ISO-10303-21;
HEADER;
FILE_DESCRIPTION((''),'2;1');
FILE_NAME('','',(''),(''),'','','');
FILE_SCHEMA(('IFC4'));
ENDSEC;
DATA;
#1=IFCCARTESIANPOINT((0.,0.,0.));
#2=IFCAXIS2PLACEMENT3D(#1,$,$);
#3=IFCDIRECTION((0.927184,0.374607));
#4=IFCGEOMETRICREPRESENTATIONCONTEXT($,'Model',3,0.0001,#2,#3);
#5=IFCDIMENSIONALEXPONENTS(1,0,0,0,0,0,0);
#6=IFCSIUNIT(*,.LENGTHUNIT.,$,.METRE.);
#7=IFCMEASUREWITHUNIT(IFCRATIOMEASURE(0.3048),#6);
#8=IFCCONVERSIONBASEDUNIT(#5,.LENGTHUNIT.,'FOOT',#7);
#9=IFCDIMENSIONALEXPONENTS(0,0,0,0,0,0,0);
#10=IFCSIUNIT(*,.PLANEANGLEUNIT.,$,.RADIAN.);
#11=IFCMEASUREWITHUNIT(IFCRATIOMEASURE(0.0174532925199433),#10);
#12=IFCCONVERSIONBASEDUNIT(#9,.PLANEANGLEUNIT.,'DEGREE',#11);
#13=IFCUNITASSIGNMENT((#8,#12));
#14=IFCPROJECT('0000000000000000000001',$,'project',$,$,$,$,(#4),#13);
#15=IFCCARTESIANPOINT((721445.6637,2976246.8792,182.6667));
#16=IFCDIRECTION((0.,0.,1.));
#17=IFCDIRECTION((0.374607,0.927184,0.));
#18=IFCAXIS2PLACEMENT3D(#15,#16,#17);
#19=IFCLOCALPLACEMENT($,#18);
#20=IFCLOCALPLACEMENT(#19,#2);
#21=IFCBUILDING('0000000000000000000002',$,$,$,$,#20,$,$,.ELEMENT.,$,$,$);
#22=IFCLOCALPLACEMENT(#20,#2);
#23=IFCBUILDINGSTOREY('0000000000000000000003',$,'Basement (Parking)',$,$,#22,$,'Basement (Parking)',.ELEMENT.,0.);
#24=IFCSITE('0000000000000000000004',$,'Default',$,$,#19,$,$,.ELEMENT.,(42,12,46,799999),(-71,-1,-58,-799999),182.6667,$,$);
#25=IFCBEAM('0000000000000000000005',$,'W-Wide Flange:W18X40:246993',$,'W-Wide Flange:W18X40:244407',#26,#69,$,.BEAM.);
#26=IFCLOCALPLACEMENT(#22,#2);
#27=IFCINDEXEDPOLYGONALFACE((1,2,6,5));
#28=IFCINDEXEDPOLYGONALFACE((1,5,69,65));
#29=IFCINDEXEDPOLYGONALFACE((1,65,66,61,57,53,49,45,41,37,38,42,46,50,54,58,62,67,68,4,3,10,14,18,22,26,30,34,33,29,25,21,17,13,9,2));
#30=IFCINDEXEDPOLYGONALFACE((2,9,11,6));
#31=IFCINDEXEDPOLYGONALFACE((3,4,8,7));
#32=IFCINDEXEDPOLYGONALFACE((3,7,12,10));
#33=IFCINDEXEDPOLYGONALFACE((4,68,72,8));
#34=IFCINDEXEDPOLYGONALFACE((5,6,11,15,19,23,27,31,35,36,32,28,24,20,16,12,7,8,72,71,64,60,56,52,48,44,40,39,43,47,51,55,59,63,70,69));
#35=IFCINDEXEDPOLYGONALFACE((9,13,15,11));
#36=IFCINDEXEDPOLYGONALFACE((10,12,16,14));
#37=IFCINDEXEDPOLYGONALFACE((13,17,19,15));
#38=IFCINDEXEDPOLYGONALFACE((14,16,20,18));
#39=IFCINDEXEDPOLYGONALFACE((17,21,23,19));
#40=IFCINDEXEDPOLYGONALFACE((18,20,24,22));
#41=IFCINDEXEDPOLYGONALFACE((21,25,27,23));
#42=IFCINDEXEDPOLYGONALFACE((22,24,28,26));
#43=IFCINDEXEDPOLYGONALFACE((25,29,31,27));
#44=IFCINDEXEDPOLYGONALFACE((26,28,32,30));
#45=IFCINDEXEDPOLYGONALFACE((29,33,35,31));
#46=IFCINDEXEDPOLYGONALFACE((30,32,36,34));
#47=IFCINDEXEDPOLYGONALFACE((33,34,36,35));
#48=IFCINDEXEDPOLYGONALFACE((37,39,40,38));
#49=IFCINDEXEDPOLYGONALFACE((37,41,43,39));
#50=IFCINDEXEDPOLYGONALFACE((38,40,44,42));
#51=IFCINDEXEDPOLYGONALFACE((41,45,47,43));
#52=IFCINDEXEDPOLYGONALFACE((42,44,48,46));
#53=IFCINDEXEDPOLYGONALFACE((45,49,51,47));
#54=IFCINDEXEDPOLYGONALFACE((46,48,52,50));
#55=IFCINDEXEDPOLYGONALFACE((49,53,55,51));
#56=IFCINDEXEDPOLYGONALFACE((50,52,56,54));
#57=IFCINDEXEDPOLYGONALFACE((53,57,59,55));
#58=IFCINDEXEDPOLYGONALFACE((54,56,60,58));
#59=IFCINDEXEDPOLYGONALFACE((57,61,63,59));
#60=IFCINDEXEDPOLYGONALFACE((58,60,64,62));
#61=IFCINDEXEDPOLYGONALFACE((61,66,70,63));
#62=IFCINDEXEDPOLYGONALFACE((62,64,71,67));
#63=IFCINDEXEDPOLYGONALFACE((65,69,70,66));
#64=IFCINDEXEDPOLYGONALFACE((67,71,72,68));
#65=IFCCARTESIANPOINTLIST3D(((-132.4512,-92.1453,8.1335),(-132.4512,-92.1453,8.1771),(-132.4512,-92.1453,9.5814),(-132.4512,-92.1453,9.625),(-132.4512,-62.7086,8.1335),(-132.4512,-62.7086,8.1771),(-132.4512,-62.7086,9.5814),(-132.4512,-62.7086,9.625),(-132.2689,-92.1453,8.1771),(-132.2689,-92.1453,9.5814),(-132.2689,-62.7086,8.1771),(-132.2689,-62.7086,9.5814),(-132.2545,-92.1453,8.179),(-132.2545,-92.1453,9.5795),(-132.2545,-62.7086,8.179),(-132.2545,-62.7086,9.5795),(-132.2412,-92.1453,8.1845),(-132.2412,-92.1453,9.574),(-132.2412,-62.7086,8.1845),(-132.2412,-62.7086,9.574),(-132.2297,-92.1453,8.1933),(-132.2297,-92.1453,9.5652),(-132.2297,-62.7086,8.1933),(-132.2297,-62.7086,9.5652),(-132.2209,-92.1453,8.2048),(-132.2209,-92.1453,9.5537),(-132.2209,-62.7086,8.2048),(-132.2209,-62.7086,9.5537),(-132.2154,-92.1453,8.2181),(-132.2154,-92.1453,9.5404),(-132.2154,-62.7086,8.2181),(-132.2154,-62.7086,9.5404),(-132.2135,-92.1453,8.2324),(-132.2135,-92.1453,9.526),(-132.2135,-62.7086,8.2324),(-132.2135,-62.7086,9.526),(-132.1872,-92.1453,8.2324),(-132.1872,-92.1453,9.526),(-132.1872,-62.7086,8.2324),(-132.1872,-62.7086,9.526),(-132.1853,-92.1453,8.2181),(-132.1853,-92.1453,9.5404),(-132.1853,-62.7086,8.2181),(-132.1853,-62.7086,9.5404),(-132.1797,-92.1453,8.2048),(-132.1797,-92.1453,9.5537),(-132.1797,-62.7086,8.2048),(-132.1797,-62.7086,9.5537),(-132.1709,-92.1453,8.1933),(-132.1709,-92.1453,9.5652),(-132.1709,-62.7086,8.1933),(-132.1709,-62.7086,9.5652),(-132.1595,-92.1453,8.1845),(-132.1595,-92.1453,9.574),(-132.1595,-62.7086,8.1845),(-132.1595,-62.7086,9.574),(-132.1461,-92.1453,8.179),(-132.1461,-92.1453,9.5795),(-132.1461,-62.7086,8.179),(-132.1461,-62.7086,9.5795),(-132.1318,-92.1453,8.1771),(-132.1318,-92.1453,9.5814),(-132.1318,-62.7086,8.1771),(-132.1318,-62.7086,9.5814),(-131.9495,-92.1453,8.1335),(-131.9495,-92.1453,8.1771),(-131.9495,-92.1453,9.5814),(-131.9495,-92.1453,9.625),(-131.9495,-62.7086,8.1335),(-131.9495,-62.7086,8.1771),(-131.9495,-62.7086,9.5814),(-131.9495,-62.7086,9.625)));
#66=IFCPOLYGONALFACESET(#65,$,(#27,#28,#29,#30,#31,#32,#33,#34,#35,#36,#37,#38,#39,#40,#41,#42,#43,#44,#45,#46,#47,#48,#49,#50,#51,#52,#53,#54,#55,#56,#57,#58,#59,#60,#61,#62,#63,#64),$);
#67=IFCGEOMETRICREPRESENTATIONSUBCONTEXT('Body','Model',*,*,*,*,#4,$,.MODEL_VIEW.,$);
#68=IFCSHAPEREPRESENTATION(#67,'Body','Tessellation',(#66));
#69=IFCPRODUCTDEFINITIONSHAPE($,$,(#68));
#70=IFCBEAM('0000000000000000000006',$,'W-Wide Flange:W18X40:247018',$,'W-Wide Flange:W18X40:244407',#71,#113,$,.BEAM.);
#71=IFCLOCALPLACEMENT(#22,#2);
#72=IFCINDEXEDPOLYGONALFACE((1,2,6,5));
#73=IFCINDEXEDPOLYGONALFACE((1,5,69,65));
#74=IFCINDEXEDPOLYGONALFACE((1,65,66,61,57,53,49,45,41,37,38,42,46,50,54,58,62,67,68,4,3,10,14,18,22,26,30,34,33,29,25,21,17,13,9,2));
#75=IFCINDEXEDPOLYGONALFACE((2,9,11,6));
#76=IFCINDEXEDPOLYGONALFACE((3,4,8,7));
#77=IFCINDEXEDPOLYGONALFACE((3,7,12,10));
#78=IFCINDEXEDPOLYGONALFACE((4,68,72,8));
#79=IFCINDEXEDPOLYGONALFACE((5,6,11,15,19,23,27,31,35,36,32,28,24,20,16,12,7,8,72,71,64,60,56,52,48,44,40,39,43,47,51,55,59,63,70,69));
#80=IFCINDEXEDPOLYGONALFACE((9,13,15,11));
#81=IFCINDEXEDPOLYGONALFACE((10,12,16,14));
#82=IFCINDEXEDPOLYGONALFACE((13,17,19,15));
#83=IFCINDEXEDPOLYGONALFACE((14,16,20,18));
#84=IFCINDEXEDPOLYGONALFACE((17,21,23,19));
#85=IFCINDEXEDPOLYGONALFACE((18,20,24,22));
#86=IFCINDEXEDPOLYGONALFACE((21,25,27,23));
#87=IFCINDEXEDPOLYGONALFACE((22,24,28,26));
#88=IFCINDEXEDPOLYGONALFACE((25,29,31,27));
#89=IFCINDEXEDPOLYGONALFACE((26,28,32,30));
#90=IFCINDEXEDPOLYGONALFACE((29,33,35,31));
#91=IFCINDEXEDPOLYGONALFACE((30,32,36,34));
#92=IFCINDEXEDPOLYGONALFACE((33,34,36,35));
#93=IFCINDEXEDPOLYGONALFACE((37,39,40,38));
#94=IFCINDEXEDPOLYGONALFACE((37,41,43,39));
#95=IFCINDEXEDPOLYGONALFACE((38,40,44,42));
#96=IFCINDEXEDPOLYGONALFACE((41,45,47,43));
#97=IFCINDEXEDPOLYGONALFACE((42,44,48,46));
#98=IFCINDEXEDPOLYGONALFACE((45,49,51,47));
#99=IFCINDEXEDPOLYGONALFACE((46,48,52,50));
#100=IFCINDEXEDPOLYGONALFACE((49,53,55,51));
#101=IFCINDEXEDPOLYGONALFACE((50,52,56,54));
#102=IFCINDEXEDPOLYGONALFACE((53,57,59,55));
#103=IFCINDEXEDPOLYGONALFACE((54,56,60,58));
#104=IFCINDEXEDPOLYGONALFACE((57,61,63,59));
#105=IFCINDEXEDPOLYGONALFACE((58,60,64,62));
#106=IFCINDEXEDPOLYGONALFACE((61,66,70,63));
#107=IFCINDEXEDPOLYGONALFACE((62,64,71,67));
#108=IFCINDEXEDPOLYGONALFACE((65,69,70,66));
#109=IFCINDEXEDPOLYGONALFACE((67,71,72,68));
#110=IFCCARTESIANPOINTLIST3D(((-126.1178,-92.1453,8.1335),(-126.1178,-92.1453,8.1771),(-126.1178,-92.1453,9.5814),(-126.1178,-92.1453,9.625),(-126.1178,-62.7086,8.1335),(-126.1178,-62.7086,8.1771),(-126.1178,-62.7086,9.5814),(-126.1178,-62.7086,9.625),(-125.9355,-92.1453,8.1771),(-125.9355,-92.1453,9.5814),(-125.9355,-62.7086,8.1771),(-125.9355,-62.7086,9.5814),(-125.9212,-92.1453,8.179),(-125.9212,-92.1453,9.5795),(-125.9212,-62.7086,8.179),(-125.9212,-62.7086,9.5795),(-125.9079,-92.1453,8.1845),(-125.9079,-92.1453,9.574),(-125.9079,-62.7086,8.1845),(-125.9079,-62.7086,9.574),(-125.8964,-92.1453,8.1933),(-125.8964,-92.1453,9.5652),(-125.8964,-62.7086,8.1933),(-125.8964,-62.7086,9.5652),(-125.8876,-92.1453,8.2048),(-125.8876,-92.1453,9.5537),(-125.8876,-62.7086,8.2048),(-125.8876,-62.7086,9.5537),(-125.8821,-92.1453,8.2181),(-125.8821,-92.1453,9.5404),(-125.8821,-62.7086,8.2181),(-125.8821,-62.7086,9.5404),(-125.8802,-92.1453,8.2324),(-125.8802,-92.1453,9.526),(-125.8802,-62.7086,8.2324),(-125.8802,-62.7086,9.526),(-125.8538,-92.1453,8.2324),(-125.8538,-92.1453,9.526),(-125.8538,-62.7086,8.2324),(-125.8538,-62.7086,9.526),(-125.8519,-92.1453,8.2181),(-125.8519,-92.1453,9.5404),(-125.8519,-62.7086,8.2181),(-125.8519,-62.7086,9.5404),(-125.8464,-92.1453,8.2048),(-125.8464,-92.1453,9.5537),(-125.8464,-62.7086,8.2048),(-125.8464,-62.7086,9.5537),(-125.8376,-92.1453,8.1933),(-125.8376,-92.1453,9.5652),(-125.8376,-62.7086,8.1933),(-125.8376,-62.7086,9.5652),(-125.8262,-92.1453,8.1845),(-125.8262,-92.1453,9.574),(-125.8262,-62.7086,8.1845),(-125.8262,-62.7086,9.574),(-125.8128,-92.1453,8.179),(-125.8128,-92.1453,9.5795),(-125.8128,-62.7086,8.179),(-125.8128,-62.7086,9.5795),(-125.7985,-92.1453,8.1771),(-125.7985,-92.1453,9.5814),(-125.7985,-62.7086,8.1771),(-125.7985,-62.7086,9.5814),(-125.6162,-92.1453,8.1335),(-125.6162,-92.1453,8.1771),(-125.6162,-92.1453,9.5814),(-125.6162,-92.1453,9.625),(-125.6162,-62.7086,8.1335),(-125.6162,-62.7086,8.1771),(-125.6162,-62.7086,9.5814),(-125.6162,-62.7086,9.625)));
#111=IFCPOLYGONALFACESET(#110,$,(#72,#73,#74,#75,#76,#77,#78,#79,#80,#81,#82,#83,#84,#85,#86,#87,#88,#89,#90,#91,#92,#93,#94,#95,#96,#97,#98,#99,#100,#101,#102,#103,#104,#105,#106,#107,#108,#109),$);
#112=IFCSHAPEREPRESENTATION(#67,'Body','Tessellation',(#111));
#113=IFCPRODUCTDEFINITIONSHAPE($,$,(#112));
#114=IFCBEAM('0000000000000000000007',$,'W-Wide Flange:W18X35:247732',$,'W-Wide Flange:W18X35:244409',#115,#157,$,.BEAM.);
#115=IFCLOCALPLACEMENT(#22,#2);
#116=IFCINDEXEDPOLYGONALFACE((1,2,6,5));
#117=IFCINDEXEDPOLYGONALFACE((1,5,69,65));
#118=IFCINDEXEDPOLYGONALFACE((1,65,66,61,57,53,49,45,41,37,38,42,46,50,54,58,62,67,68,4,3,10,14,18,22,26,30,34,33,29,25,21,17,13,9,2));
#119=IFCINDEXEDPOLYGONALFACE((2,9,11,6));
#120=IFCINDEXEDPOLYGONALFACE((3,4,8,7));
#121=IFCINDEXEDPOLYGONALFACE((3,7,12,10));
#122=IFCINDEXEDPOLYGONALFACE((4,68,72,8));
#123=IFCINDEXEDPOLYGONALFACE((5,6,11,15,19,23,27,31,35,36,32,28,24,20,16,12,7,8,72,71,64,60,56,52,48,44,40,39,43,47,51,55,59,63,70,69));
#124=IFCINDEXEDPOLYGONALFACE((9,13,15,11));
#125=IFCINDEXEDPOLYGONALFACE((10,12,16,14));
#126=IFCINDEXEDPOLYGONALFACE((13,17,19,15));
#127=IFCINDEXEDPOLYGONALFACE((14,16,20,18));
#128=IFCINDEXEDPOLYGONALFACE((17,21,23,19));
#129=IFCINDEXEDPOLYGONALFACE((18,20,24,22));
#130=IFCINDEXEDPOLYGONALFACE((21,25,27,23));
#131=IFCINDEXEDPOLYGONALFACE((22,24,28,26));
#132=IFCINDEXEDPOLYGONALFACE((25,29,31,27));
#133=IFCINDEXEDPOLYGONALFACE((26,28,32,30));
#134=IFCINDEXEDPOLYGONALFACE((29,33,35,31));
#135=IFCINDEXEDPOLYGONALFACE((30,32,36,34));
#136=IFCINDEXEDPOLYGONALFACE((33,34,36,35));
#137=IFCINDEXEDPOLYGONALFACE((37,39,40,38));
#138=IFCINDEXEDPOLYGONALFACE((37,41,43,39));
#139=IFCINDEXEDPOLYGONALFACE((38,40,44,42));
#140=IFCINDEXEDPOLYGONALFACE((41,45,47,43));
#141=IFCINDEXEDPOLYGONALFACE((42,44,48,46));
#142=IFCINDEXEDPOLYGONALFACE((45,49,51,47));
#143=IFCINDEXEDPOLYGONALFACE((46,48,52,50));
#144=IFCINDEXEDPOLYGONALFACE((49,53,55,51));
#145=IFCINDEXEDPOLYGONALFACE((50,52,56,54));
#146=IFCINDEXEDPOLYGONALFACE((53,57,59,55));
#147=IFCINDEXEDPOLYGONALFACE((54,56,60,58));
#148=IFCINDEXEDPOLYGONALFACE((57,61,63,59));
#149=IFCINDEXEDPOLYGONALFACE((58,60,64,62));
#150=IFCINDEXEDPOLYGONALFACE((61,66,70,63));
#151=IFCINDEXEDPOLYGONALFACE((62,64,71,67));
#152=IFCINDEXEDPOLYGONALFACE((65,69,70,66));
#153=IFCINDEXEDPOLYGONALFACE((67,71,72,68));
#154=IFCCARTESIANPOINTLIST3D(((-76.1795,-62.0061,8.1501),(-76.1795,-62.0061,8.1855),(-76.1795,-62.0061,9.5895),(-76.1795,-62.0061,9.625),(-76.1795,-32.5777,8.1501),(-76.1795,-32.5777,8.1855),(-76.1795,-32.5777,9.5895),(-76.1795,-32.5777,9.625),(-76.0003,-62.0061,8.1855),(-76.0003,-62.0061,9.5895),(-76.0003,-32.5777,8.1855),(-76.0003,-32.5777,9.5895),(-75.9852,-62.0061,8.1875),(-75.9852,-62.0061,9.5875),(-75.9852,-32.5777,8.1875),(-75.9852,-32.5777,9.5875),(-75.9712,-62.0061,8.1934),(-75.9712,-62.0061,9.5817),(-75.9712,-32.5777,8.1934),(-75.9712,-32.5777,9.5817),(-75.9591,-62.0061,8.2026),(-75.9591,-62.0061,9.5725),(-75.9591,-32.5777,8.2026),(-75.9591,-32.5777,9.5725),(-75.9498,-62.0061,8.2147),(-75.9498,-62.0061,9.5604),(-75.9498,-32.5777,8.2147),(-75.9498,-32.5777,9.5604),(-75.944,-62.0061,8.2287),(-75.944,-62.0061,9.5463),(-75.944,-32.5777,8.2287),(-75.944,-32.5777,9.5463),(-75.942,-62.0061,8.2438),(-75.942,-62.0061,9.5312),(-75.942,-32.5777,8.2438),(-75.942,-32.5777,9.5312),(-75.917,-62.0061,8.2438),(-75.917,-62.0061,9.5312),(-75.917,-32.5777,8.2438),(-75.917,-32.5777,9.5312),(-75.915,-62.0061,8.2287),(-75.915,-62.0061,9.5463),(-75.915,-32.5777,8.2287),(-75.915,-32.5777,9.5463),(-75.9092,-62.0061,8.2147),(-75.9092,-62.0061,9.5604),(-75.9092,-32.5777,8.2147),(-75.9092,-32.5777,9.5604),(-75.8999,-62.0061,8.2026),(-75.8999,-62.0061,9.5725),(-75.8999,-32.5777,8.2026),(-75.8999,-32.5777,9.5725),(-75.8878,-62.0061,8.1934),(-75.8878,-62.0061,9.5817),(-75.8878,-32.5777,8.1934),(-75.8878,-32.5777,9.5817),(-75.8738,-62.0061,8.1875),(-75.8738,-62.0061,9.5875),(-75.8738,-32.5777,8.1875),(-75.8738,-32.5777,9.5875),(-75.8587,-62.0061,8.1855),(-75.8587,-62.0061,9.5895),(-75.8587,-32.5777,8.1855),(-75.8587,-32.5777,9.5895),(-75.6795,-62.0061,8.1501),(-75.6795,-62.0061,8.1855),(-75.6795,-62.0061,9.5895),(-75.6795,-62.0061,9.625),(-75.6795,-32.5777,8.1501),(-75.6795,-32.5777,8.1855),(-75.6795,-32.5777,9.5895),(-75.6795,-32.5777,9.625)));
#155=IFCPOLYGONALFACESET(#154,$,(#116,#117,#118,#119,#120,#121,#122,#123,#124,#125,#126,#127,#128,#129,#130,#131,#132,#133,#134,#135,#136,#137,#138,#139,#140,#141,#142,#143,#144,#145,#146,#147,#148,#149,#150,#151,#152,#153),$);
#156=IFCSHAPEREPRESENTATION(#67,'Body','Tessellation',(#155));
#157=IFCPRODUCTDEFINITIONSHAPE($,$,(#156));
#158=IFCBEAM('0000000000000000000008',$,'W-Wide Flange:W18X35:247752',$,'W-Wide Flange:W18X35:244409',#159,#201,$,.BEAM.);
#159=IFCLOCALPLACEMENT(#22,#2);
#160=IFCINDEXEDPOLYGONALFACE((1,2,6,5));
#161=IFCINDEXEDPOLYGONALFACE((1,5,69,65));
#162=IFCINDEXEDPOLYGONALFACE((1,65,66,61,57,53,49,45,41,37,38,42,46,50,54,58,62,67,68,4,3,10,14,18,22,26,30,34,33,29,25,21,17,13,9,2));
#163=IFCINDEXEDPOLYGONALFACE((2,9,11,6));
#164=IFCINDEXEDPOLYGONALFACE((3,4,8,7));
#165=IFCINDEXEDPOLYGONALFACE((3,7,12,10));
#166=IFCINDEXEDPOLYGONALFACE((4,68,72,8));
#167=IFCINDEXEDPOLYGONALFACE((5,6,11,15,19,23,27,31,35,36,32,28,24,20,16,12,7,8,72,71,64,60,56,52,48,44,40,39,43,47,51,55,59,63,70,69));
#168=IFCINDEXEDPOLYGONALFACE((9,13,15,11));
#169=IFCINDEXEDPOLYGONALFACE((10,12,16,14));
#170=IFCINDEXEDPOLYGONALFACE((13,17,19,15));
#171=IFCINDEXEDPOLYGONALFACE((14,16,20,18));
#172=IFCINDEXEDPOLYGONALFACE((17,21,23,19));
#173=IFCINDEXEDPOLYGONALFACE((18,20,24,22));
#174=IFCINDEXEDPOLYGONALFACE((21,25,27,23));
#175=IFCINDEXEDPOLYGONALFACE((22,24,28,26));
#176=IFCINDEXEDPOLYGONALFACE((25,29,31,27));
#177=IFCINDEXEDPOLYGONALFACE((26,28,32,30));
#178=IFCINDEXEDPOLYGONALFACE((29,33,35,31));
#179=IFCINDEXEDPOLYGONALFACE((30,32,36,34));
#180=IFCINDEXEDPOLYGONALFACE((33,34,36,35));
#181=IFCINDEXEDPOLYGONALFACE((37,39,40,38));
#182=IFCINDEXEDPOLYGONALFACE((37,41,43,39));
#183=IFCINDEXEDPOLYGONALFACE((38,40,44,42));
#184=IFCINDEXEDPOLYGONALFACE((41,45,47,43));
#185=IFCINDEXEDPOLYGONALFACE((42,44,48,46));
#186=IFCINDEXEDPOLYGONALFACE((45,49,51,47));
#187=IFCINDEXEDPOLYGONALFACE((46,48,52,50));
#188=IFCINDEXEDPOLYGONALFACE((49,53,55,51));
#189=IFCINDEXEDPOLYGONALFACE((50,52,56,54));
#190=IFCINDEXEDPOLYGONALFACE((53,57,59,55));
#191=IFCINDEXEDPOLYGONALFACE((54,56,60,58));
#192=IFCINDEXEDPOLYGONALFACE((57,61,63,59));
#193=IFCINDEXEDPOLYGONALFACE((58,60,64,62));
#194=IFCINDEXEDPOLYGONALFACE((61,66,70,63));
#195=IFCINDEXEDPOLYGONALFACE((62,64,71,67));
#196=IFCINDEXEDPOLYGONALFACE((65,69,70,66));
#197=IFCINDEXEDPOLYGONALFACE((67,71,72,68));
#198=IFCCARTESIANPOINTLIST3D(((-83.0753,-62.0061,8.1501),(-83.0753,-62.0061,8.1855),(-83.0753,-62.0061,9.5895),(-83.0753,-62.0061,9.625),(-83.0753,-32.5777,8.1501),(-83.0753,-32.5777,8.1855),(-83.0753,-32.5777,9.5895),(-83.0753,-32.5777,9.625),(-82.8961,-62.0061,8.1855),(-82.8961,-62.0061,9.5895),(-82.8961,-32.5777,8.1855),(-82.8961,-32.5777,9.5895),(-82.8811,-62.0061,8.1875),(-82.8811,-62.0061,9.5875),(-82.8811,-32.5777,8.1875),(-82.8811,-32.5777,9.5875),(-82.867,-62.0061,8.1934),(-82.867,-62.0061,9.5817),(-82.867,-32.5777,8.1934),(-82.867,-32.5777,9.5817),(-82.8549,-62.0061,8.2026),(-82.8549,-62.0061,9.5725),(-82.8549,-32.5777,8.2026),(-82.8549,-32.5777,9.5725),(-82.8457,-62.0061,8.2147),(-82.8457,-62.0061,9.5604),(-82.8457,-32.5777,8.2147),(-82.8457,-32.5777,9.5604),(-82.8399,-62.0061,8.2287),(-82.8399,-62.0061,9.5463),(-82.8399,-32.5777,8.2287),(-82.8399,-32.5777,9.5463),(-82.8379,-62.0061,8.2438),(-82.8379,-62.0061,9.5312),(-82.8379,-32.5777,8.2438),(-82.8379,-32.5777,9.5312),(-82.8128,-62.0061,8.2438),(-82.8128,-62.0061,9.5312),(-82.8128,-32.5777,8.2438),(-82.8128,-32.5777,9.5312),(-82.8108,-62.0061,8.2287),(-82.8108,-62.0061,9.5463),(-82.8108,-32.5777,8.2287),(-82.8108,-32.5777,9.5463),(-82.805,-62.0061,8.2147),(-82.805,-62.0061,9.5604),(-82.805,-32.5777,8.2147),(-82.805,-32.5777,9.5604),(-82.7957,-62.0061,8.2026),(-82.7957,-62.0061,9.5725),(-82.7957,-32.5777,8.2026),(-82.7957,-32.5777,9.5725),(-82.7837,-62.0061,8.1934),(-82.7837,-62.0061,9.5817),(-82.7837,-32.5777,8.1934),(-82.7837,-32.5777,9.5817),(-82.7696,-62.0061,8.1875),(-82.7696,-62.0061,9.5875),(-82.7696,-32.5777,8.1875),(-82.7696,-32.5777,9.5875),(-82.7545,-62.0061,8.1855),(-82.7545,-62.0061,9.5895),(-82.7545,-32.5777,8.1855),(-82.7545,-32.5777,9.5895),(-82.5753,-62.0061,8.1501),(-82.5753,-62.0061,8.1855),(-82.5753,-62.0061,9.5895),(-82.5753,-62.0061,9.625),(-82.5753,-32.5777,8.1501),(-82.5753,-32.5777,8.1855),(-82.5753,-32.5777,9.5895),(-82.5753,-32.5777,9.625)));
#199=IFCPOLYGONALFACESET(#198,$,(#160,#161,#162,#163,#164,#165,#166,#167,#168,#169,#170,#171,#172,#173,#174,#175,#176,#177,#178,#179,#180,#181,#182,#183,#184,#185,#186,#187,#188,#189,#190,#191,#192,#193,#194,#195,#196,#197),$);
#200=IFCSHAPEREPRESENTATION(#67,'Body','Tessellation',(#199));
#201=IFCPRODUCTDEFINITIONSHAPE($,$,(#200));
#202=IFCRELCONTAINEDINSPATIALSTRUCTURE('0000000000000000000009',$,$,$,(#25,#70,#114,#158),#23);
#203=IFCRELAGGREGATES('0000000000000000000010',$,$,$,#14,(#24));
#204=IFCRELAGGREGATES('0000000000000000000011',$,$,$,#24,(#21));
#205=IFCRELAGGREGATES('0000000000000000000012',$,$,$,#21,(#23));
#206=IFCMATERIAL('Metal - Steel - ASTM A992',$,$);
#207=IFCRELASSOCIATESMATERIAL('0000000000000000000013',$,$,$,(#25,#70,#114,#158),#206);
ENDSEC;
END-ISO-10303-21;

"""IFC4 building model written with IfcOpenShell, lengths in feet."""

from ifc_helpers import new_model, entity, si_unit, converted_unit, direction, frame, frame_2d, origin, place, context, subcontext, project, spatial, i_section, extrude, material, element, save


model = new_model("IFC4")

# Units and contexts
model_context = context("Model", 3, precision=0.0001, world=origin(), true_north=direction((0.927184, 0.374607)))
body_context = subcontext(model_context, "Body", "Model", "MODEL_VIEW")
ifc_project = project(units=[converted_unit("LENGTHUNIT", "FOOT", entity("IfcRatioMeasure", 0.3048), si_unit("LENGTHUNIT", "METRE"), dimensions=[1, 0, 0, 0, 0, 0, 0]), converted_unit("PLANEANGLEUNIT", "DEGREE", entity("IfcRatioMeasure", 0.0174532925199433), si_unit("PLANEANGLEUNIT", "RADIAN"), dimensions=[0, 0, 0, 0, 0, 0, 0])], contexts=[model_context])

# Site, building, storey
site_placement = place(None, frame((721445.6637, 2976246.8792, 182.6667), z_axis=(0.0, 0.0, 1.0), x_axis=(0.374607, 0.927184, 0.0)))
site = spatial("IfcSite", under=ifc_project, at=site_placement, Name="Default", CompositionType="ELEMENT", RefLatitude=(42, 12, 46, 799999), RefLongitude=(-71, -1, -58, -799999), RefElevation=182.6667)
building_placement = place(site_placement, origin())
building = spatial("IfcBuilding", under=site, at=building_placement, CompositionType="ELEMENT")
storey_placement = place(building_placement, origin())
storey = spatial("IfcBuildingStorey", under=building, at=storey_placement, Name="Basement (Parking)", LongName="Basement (Parking)", CompositionType="ELEMENT", Elevation=0.0)

# Shared definitions
ifc_material_1 = material(Name="Metal - Steel - ASTM A992")

# Beams
beam_1_placement = place(storey_placement, frame((-132.2003, -92.4378, 9.625), z_axis=(0.0, 0.0, 1.0), x_axis=(0.0, 1.0, 0.0)))
element("IfcBeam", 1, at=beam_1_placement, inside=storey, material=ifc_material_1, Name="W-Wide Flange:W18X40:246993", ObjectType="W-Wide Flange:W18X40:244407", PredefinedType="BEAM", context=body_context, shape_type="SweptSolid", body=[
    extrude(i_section(OverallWidth=0.5016, OverallDepth=1.4915, WebThickness=0.0264, FlangeThickness=0.0436, FilletRadius=0.0553, at=frame_2d((0.0, 0.0), x_axis=(0.0, 1.0))), frame((0.2925, 0.0, -0.7458), z_axis=(1.0, 0.0, 0.0), x_axis=(0.0, 0.0, -1.0)), (0.0, 0.0, 1.0), 29.4367),
])
beam_2_placement = place(storey_placement, frame((-125.867, -92.4378, 9.625), z_axis=(0.0, 0.0, 1.0), x_axis=(0.0, 1.0, 0.0)))
element("IfcBeam", 2, at=beam_2_placement, inside=storey, material=ifc_material_1, Name="W-Wide Flange:W18X40:247018", ObjectType="W-Wide Flange:W18X40:244407", PredefinedType="BEAM", context=body_context, shape_type="SweptSolid", body=[
    extrude(i_section(OverallWidth=0.5016, OverallDepth=1.4915, WebThickness=0.0264, FlangeThickness=0.0436, FilletRadius=0.0553, at=frame_2d((0.0, 0.0), x_axis=(0.0, 1.0))), frame((0.2925, 0.0, -0.7458), z_axis=(1.0, 0.0, 0.0), x_axis=(0.0, 0.0, -1.0)), (0.0, 0.0, 1.0), 29.4367),
])
beam_3_placement = place(storey_placement, frame((-75.9295, -62.3961, 9.625), z_axis=(0.0, 0.0, 1.0), x_axis=(0.0, 1.0, 0.0)))
element("IfcBeam", 3, at=beam_3_placement, inside=storey, material=ifc_material_1, Name="W-Wide Flange:W18X35:247732", ObjectType="W-Wide Flange:W18X35:244409", PredefinedType="BEAM", context=body_context, shape_type="SweptSolid", body=[
    extrude(i_section(OverallWidth=0.5, OverallDepth=1.4749, WebThickness=0.0251, FlangeThickness=0.0355, FilletRadius=0.0583, at=frame_2d((0.0, 0.0), x_axis=(0.0, 1.0))), frame((0.39, 0.0, -0.7375), z_axis=(1.0, 0.0, 0.0), x_axis=(0.0, 0.0, -1.0)), (0.0, 0.0, 1.0), 29.4284),
])
beam_4_placement = place(storey_placement, frame((-82.8253, -62.3961, 9.625), z_axis=(0.0, 0.0, 1.0), x_axis=(0.0, 1.0, 0.0)))
element("IfcBeam", 4, at=beam_4_placement, inside=storey, material=ifc_material_1, Name="W-Wide Flange:W18X35:247752", ObjectType="W-Wide Flange:W18X35:244409", PredefinedType="BEAM", context=body_context, shape_type="SweptSolid", body=[
    extrude(i_section(OverallWidth=0.5, OverallDepth=1.4749, WebThickness=0.0251, FlangeThickness=0.0355, FilletRadius=0.0583, at=frame_2d((0.0, 0.0), x_axis=(0.0, 1.0))), frame((0.39, 0.0, -0.7375), z_axis=(1.0, 0.0, 0.0), x_axis=(0.0, 0.0, -1.0)), (0.0, 0.0, 1.0), 29.4284),
])

save(model, "model.ifc")
